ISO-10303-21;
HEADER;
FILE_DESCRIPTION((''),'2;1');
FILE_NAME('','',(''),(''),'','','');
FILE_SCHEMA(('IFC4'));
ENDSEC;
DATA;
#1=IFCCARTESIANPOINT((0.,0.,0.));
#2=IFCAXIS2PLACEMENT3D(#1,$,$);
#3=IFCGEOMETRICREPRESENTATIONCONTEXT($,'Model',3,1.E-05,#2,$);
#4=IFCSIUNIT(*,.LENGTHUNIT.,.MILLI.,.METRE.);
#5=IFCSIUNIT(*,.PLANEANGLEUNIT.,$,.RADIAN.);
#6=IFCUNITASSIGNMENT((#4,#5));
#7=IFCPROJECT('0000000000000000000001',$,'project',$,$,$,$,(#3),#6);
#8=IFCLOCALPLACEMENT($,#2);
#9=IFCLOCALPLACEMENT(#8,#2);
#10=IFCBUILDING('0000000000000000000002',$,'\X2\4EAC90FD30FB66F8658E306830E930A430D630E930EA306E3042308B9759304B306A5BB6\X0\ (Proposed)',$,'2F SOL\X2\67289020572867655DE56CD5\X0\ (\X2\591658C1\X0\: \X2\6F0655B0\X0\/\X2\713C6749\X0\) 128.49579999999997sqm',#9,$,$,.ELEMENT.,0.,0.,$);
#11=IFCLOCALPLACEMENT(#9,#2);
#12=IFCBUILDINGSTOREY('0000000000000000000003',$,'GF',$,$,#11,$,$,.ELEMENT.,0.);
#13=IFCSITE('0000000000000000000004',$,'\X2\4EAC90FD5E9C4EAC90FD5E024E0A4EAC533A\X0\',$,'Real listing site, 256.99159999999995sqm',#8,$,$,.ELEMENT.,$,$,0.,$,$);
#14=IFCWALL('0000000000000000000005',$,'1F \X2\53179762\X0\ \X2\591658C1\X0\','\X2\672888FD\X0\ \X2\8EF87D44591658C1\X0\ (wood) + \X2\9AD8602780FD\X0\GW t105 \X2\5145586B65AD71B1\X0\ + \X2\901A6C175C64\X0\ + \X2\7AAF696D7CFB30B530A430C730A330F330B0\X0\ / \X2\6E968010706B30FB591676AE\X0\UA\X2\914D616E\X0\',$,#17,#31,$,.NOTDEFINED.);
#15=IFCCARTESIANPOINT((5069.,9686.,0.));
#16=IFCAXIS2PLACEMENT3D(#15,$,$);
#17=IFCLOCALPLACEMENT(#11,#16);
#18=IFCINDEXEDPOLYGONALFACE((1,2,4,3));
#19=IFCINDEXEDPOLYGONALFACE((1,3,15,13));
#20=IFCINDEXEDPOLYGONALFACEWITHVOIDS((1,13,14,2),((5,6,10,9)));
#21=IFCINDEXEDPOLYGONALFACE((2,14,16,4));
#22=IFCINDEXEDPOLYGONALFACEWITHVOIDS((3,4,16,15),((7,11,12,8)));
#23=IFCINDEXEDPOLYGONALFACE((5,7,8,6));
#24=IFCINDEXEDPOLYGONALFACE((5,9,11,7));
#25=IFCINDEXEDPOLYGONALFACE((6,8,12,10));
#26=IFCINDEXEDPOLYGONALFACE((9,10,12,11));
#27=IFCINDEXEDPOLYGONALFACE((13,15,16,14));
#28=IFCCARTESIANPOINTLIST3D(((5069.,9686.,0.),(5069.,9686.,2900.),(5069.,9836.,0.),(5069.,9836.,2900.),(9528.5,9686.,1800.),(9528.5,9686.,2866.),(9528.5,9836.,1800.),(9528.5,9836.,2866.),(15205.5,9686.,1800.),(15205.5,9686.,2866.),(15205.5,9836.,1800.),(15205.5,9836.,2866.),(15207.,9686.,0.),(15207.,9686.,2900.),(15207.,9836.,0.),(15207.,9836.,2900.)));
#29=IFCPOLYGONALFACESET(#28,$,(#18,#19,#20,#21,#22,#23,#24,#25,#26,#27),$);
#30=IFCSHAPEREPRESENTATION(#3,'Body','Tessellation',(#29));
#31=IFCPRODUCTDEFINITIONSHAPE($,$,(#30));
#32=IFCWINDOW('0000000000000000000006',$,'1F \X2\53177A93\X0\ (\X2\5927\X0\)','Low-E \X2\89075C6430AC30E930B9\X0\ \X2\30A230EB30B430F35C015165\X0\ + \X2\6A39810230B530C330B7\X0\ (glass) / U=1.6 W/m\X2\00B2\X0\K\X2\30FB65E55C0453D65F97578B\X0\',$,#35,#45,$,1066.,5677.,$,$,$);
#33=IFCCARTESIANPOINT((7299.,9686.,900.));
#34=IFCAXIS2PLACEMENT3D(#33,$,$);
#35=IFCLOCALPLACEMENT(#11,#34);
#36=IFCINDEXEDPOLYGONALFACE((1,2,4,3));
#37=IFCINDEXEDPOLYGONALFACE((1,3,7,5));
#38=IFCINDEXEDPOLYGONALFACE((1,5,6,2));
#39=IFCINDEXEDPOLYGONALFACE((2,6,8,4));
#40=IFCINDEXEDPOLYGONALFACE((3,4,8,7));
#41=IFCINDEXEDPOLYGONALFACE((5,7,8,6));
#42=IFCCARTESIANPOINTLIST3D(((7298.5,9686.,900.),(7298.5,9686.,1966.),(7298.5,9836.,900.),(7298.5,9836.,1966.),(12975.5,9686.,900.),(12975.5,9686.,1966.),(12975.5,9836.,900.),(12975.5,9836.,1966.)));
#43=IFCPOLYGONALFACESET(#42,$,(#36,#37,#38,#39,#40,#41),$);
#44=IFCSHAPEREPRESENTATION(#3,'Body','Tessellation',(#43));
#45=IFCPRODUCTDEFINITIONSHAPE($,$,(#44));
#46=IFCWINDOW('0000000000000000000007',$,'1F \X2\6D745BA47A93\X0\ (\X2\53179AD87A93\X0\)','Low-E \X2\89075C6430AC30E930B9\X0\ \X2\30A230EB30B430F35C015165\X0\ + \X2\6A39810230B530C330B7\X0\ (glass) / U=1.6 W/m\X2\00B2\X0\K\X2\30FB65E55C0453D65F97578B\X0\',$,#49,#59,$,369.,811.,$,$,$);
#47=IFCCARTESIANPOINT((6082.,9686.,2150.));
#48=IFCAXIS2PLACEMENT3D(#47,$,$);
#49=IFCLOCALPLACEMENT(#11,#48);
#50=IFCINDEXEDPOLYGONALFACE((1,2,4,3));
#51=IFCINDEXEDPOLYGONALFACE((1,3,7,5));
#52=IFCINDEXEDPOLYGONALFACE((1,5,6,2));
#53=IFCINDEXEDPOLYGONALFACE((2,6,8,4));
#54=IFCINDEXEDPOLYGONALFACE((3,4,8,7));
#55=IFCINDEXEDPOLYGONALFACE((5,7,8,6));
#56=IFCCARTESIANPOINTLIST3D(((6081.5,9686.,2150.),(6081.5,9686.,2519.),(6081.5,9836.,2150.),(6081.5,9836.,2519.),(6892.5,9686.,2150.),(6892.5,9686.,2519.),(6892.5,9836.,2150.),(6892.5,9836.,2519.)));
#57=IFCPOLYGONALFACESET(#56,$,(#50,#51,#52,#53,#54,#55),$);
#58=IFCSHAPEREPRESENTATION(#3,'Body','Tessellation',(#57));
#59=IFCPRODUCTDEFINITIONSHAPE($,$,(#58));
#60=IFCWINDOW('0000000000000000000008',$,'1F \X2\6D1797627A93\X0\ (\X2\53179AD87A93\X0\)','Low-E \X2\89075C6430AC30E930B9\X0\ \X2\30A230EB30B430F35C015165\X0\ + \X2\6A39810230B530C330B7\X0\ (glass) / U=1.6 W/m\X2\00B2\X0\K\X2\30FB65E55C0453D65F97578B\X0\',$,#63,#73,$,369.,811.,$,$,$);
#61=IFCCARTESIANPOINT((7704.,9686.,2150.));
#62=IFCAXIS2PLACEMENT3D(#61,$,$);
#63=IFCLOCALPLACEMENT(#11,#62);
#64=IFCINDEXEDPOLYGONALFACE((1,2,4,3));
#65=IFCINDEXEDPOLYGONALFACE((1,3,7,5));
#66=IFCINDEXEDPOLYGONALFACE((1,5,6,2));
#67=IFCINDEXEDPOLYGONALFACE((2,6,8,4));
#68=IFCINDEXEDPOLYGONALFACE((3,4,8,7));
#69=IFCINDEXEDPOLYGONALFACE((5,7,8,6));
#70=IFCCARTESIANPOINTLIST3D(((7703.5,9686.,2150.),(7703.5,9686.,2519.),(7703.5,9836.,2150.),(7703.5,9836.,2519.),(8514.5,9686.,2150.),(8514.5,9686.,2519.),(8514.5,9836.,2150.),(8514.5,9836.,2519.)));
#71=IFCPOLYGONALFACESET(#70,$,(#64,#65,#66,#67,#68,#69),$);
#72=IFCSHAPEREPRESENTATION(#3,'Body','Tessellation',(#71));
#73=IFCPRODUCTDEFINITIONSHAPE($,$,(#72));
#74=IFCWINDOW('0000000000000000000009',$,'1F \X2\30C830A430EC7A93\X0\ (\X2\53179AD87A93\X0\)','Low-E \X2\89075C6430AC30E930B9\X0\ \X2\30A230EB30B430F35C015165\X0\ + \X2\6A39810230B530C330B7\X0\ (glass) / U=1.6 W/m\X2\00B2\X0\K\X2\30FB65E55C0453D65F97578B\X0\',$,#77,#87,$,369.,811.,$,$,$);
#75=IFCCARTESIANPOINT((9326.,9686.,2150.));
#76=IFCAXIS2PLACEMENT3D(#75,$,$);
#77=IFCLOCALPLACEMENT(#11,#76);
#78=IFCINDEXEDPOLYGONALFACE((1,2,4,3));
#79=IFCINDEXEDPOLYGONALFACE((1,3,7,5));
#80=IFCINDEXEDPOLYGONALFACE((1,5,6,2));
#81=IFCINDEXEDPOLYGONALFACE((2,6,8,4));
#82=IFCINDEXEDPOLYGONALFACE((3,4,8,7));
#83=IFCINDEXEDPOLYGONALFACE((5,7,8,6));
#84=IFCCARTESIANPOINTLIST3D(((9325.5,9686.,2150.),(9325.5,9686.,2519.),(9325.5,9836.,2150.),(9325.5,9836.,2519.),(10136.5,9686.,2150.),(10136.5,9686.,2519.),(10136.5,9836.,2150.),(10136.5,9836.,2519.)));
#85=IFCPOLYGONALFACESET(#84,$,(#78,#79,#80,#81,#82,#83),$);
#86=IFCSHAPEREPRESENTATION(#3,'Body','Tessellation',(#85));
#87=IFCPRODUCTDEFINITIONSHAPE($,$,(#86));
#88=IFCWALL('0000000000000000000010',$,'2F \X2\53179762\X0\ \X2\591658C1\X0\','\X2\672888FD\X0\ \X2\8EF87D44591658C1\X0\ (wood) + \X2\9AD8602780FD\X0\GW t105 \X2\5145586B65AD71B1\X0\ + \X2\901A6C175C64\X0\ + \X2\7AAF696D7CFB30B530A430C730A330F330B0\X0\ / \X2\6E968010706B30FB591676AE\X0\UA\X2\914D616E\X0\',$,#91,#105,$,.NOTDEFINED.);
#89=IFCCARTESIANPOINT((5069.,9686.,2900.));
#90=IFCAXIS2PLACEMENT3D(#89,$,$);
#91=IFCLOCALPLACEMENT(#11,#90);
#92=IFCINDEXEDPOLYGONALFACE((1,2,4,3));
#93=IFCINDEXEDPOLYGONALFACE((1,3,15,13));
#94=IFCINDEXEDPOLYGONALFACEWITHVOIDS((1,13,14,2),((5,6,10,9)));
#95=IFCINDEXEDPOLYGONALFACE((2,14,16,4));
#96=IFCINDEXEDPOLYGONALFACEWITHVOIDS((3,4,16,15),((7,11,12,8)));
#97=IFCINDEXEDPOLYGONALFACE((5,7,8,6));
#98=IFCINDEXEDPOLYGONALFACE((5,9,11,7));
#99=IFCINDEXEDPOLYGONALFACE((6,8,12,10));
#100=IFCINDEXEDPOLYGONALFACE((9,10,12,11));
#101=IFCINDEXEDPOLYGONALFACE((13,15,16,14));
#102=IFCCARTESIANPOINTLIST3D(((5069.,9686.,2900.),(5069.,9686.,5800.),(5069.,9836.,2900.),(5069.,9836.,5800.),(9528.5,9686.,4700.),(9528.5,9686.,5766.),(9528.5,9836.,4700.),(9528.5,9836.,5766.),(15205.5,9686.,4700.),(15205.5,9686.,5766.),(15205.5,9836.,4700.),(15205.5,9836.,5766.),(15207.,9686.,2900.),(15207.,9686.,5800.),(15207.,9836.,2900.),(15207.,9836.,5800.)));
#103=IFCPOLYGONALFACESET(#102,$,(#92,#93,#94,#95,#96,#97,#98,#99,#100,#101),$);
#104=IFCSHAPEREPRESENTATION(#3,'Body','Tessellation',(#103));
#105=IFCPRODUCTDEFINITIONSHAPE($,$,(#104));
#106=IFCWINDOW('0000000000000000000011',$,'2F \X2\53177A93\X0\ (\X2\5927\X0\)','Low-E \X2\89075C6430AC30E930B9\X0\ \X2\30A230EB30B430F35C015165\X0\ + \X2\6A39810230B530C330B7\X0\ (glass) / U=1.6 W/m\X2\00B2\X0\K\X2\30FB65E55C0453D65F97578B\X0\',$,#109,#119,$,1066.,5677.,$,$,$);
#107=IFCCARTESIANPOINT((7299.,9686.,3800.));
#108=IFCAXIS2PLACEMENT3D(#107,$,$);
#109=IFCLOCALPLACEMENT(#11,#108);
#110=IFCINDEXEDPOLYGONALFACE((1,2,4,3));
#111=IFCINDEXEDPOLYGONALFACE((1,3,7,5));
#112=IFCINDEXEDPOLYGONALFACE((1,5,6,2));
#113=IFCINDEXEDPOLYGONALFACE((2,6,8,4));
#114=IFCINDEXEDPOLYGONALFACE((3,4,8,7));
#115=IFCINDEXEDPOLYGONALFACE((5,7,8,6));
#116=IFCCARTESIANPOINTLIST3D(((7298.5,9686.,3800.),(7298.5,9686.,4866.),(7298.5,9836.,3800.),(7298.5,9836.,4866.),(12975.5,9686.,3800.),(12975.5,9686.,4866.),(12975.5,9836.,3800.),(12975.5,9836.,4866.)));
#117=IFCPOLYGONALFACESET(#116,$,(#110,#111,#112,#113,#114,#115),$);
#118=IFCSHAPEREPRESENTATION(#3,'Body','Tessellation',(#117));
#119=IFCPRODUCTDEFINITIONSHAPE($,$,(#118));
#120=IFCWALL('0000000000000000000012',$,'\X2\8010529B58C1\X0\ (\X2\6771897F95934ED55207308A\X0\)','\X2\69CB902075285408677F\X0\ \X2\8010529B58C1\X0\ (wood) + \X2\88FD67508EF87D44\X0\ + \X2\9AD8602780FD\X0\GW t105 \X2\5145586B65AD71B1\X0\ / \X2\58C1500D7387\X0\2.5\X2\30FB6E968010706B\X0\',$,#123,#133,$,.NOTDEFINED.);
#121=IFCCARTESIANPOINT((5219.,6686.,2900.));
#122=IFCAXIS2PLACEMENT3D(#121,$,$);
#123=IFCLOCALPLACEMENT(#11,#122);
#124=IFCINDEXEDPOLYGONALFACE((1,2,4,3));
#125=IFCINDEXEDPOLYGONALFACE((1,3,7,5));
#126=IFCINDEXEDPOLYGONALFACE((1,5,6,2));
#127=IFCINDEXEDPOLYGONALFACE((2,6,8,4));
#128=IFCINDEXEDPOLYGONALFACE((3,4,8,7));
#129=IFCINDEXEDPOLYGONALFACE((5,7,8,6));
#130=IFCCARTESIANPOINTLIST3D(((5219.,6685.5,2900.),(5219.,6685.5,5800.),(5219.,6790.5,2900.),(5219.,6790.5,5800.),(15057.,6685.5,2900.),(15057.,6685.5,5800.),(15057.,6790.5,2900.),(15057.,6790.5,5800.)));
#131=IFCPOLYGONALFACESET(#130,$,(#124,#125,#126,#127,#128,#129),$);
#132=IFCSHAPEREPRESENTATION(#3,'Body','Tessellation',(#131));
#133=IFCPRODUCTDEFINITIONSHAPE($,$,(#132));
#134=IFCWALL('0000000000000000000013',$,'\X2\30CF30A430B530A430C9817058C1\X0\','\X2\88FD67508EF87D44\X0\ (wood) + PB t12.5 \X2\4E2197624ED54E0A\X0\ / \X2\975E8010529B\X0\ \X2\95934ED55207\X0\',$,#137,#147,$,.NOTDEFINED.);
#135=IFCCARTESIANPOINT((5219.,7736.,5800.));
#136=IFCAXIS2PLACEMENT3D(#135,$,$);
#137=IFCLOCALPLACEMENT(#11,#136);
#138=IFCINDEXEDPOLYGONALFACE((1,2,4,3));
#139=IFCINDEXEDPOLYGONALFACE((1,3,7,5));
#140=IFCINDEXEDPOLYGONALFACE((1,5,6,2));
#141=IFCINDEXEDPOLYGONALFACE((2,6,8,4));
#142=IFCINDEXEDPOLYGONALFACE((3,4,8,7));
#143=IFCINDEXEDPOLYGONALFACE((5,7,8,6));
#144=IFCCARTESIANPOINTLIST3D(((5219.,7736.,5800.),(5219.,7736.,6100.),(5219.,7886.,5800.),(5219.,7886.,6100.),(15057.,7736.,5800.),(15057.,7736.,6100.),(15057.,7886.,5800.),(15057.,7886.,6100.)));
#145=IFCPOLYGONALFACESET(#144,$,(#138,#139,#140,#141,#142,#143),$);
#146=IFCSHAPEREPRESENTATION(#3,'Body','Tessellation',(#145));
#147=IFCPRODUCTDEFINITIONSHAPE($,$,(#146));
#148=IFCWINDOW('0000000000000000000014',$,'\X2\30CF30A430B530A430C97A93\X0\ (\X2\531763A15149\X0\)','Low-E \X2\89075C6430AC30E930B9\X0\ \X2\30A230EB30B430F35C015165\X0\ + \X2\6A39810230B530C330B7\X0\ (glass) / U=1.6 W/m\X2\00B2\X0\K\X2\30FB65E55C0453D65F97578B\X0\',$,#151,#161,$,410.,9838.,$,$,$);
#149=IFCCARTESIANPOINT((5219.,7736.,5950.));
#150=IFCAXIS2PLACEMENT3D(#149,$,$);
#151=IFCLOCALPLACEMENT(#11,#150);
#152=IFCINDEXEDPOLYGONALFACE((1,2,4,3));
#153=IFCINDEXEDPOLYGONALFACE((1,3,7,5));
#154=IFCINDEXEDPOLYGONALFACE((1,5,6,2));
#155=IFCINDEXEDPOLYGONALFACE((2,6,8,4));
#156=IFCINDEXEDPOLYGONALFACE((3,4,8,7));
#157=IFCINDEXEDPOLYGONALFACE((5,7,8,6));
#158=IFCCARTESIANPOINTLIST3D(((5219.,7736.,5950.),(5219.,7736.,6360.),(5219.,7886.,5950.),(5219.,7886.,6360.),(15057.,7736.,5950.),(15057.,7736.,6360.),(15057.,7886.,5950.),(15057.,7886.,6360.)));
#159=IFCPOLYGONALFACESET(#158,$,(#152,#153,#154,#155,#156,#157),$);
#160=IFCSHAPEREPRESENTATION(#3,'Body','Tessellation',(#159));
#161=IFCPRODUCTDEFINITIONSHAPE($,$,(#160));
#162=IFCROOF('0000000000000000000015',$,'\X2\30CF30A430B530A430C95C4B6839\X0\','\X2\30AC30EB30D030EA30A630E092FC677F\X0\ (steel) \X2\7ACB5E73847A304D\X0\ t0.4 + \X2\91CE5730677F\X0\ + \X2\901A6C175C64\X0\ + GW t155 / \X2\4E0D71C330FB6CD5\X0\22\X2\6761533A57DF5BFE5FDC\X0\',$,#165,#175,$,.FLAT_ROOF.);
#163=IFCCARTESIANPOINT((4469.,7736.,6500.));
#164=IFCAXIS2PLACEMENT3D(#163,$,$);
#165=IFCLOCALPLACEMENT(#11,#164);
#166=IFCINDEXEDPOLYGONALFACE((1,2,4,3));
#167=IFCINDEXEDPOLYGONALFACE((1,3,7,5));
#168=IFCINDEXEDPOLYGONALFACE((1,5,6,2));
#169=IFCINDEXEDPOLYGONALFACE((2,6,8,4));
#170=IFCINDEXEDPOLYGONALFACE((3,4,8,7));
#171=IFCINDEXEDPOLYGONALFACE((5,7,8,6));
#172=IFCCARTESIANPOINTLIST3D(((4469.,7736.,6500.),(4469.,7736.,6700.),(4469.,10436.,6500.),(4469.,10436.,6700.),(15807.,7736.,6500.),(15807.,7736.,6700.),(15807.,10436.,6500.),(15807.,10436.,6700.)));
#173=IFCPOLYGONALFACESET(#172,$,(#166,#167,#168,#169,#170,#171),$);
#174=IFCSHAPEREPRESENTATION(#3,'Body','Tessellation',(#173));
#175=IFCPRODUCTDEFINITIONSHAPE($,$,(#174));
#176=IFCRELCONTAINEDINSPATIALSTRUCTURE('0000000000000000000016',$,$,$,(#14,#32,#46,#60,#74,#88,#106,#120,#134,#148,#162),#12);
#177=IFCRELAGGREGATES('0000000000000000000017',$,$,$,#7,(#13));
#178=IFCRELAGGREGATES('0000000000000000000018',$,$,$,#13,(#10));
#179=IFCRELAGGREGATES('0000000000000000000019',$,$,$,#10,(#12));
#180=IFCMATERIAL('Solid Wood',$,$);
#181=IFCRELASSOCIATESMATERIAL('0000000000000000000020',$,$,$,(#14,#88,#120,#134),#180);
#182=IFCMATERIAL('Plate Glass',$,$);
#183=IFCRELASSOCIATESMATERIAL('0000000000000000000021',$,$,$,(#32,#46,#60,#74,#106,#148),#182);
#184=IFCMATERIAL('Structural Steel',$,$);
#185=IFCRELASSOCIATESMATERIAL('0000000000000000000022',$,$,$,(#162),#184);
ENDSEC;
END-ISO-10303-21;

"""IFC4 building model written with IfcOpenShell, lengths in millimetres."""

from ifc_helpers import new_model, si_unit, frame, frame_2d, origin, place, context, project, spatial, rectangle, extrude, material, element, fill, save


model = new_model("IFC4")

# Units and contexts
model_context = context("Model", 3, precision=1e-05, world=origin())
ifc_project = project(units=[si_unit("LENGTHUNIT", "METRE", prefix="MILLI"), si_unit("PLANEANGLEUNIT", "RADIAN")], contexts=[model_context])

# Site, building, storey
site_placement = place(None, origin())
site = spatial("IfcSite", under=ifc_project, at=site_placement, Name="京都府京都市上京区", ObjectType="Real listing site, 256.99159999999995sqm", CompositionType="ELEMENT", RefElevation=0.0)
building_placement = place(site_placement, origin())
building = spatial("IfcBuilding", under=site, at=building_placement, Name="京都・書斎とライブラリのある静かな家 (Proposed)", ObjectType="2F SOL木造在来工法 (外壁: 漆喰/焼杉) 128.49579999999997sqm", CompositionType="ELEMENT", ElevationOfRefHeight=0.0, ElevationOfTerrain=0.0)
storey_placement = place(building_placement, origin())
storey = spatial("IfcBuildingStorey", under=building, at=storey_placement, Name="GF", CompositionType="ELEMENT", Elevation=0.0)

# Wall, openings, windows
ifc_material_1 = material(Name="Solid Wood")
wall_1_placement = place(storey_placement, frame((5069.0, 9686.0, 0.0)))
wall_1 = element("IfcWall", 1, at=wall_1_placement, inside=storey, material=ifc_material_1, Name="1F 北面 外壁", Description="木製 軸組外壁 (wood) + 高性能GW t105 充填断熱 + 通気層 + 窯業系サイディング / 準耐火・外皮UA配慮", PredefinedType="NOTDEFINED", context=model_context, shape_type="SweptSolid", body=[
    extrude(rectangle(XDim=10138.0, YDim=150.0, at=frame_2d((5069.0, 75.0))), frame((5069.0, 9686.0, 0.0)), (0.0, 0.0, 1.0), 2900.0),
])
opening_1_placement = place(storey_placement, frame((7299.0, 9686.0, 900.0)))
opening_1 = element("IfcOpeningElement", 2, at=opening_1_placement, cuts=wall_1, PredefinedType="NOTDEFINED", context=model_context, shape_type="SweptSolid", body=[
    extrude(rectangle(XDim=5677.0, YDim=150.0, at=frame_2d((2838.0, 75.0))), frame((7299.0, 9686.0, 900.0)), (0.0, 0.0, 1.0), 1066.0),
])
opening_2_placement = place(storey_placement, frame((6082.0, 9686.0, 2150.0)))
opening_2 = element("IfcOpeningElement", 3, at=opening_2_placement, cuts=wall_1, PredefinedType="NOTDEFINED", context=model_context, shape_type="SweptSolid", body=[
    extrude(rectangle(XDim=811.0, YDim=150.0, at=frame_2d((405.0, 75.0))), frame((6082.0, 9686.0, 2150.0)), (0.0, 0.0, 1.0), 369.0),
])
opening_3_placement = place(storey_placement, frame((7704.0, 9686.0, 2150.0)))
opening_3 = element("IfcOpeningElement", 4, at=opening_3_placement, cuts=wall_1, PredefinedType="NOTDEFINED", context=model_context, shape_type="SweptSolid", body=[
    extrude(rectangle(XDim=811.0, YDim=150.0, at=frame_2d((405.0, 75.0))), frame((7704.0, 9686.0, 2150.0)), (0.0, 0.0, 1.0), 369.0),
])
opening_4_placement = place(storey_placement, frame((9326.0, 9686.0, 2150.0)))
opening_4 = element("IfcOpeningElement", 5, at=opening_4_placement, cuts=wall_1, PredefinedType="NOTDEFINED", context=model_context, shape_type="SweptSolid", body=[
    extrude(rectangle(XDim=811.0, YDim=150.0, at=frame_2d((405.0, 75.0))), frame((9326.0, 9686.0, 2150.0)), (0.0, 0.0, 1.0), 369.0),
])
ifc_material_2 = material(Name="Plate Glass")
window_1_placement = place(storey_placement, frame((7299.0, 9686.0, 900.0)))
window_1 = element("IfcWindow", 6, at=window_1_placement, inside=storey, material=ifc_material_2, Name="1F 北窓 (大)", Description="Low-E 複層ガラス アルゴン封入 + 樹脂サッシ (glass) / U=1.6 W/m²K・日射取得型", OverallHeight=1066.0, OverallWidth=5677.0, context=model_context, shape_type="SweptSolid", body=[
    extrude(rectangle(XDim=5677.0, YDim=150.0, at=frame_2d((2838.0, 75.0))), frame((7299.0, 9686.0, 900.0)), (0.0, 0.0, 1.0), 1066.0),
])
fill(opening_1, window_1)
window_2_placement = place(storey_placement, frame((6082.0, 9686.0, 2150.0)))
window_2 = element("IfcWindow", 7, at=window_2_placement, inside=storey, material=ifc_material_2, Name="1F 浴室窓 (北高窓)", Description="Low-E 複層ガラス アルゴン封入 + 樹脂サッシ (glass) / U=1.6 W/m²K・日射取得型", OverallHeight=369.0, OverallWidth=811.0, context=model_context, shape_type="SweptSolid", body=[
    extrude(rectangle(XDim=811.0, YDim=150.0, at=frame_2d((405.0, 75.0))), frame((6082.0, 9686.0, 2150.0)), (0.0, 0.0, 1.0), 369.0),
])
fill(opening_2, window_2)
window_3_placement = place(storey_placement, frame((7704.0, 9686.0, 2150.0)))
window_3 = element("IfcWindow", 8, at=window_3_placement, inside=storey, material=ifc_material_2, Name="1F 洗面窓 (北高窓)", Description="Low-E 複層ガラス アルゴン封入 + 樹脂サッシ (glass) / U=1.6 W/m²K・日射取得型", OverallHeight=369.0, OverallWidth=811.0, context=model_context, shape_type="SweptSolid", body=[
    extrude(rectangle(XDim=811.0, YDim=150.0, at=frame_2d((405.0, 75.0))), frame((7704.0, 9686.0, 2150.0)), (0.0, 0.0, 1.0), 369.0),
])
fill(opening_3, window_3)
window_4_placement = place(storey_placement, frame((9326.0, 9686.0, 2150.0)))
window_4 = element("IfcWindow", 9, at=window_4_placement, inside=storey, material=ifc_material_2, Name="1F トイレ窓 (北高窓)", Description="Low-E 複層ガラス アルゴン封入 + 樹脂サッシ (glass) / U=1.6 W/m²K・日射取得型", OverallHeight=369.0, OverallWidth=811.0, context=model_context, shape_type="SweptSolid", body=[
    extrude(rectangle(XDim=811.0, YDim=150.0, at=frame_2d((405.0, 75.0))), frame((9326.0, 9686.0, 2150.0)), (0.0, 0.0, 1.0), 369.0),
])
fill(opening_4, window_4)

# Wall, opening, window
wall_2_placement = place(storey_placement, frame((5069.0, 9686.0, 2900.0)))
wall_2 = element("IfcWall", 10, at=wall_2_placement, inside=storey, material=ifc_material_1, Name="2F 北面 外壁", Description="木製 軸組外壁 (wood) + 高性能GW t105 充填断熱 + 通気層 + 窯業系サイディング / 準耐火・外皮UA配慮", PredefinedType="NOTDEFINED", context=model_context, shape_type="SweptSolid", body=[
    extrude(rectangle(XDim=10138.0, YDim=150.0, at=frame_2d((5069.0, 75.0))), frame((5069.0, 9686.0, 2900.0)), (0.0, 0.0, 1.0), 2900.0),
])
opening_5_placement = place(storey_placement, frame((7299.0, 9686.0, 3800.0)))
opening_5 = element("IfcOpeningElement", 11, at=opening_5_placement, cuts=wall_2, PredefinedType="NOTDEFINED", context=model_context, shape_type="SweptSolid", body=[
    extrude(rectangle(XDim=5677.0, YDim=150.0, at=frame_2d((2838.0, 75.0))), frame((7299.0, 9686.0, 3800.0)), (0.0, 0.0, 1.0), 1066.0),
])
window_5_placement = place(storey_placement, frame((7299.0, 9686.0, 3800.0)))
window_5 = element("IfcWindow", 12, at=window_5_placement, inside=storey, material=ifc_material_2, Name="2F 北窓 (大)", Description="Low-E 複層ガラス アルゴン封入 + 樹脂サッシ (glass) / U=1.6 W/m²K・日射取得型", OverallHeight=1066.0, OverallWidth=5677.0, context=model_context, shape_type="SweptSolid", body=[
    extrude(rectangle(XDim=5677.0, YDim=150.0, at=frame_2d((2838.0, 75.0))), frame((7299.0, 9686.0, 3800.0)), (0.0, 0.0, 1.0), 1066.0),
])
fill(opening_5, window_5)

# Wall
wall_3_placement = place(storey_placement, frame((5219.0, 6686.0, 2900.0)))
element("IfcWall", 13, at=wall_3_placement, inside=storey, material=ifc_material_1, Name="耐力壁 (東西間仕切り)", Description="構造用合板 耐力壁 (wood) + 製材軸組 + 高性能GW t105 充填断熱 / 壁倍率2.5・準耐火", PredefinedType="NOTDEFINED", context=model_context, shape_type="SweptSolid", body=[
    extrude(rectangle(XDim=9838.0, YDim=105.0, at=frame_2d((4919.0, 52.0))), frame((5219.0, 6686.0, 2900.0)), (0.0, 0.0, 1.0), 2900.0),
])

# Wall, opening, window
wall_4_placement = place(storey_placement, frame((5219.0, 7736.0, 5800.0)))
wall_4 = element("IfcWall", 14, at=wall_4_placement, inside=storey, material=ifc_material_1, Name="ハイサイド腰壁", Description="製材軸組 (wood) + PB t12.5 両面仕上 / 非耐力 間仕切", PredefinedType="NOTDEFINED", context=model_context, shape_type="SweptSolid", body=[
    extrude(rectangle(XDim=9838.0, YDim=150.0, at=frame_2d((4919.0, 75.0))), frame((5219.0, 7736.0, 5800.0)), (0.0, 0.0, 1.0), 700.0),
])
opening_6_placement = place(storey_placement, frame((5219.0, 7736.0, 5950.0)))
opening_6 = element("IfcOpeningElement", 15, at=opening_6_placement, cuts=wall_4, PredefinedType="NOTDEFINED", context=model_context, shape_type="SweptSolid", body=[
    extrude(rectangle(XDim=9838.0, YDim=150.0, at=frame_2d((4919.0, 75.0))), frame((5219.0, 7736.0, 5950.0)), (0.0, 0.0, 1.0), 410.0),
])
window_6_placement = place(storey_placement, frame((5219.0, 7736.0, 5950.0)))
window_6 = element("IfcWindow", 16, at=window_6_placement, inside=storey, material=ifc_material_2, Name="ハイサイド窓 (北採光)", Description="Low-E 複層ガラス アルゴン封入 + 樹脂サッシ (glass) / U=1.6 W/m²K・日射取得型", OverallHeight=410.0, OverallWidth=9838.0, context=model_context, shape_type="SweptSolid", body=[
    extrude(rectangle(XDim=9838.0, YDim=150.0, at=frame_2d((4919.0, 75.0))), frame((5219.0, 7736.0, 5950.0)), (0.0, 0.0, 1.0), 410.0),
])
fill(opening_6, window_6)

# Roof
ifc_material_3 = material(Name="Structural Steel")
roof_placement = place(storey_placement, frame((4469.0, 7736.0, 6500.0)))
element("IfcRoof", 17, at=roof_placement, inside=storey, material=ifc_material_3, Name="ハイサイド屋根", Description="ガルバリウム鋼板 (steel) 立平葺き t0.4 + 野地板 + 通気層 + GW t155 / 不燃・法22条区域対応", PredefinedType="FLAT_ROOF", context=model_context, shape_type="SweptSolid", body=[
    extrude(rectangle(XDim=11338.0, YDim=2700.0, at=frame_2d((5669.0, 1350.0))), frame((4469.0, 7736.0, 6500.0)), (0.0, 0.0, 1.0), 200.0),
])

save(model, "model.ifc")
